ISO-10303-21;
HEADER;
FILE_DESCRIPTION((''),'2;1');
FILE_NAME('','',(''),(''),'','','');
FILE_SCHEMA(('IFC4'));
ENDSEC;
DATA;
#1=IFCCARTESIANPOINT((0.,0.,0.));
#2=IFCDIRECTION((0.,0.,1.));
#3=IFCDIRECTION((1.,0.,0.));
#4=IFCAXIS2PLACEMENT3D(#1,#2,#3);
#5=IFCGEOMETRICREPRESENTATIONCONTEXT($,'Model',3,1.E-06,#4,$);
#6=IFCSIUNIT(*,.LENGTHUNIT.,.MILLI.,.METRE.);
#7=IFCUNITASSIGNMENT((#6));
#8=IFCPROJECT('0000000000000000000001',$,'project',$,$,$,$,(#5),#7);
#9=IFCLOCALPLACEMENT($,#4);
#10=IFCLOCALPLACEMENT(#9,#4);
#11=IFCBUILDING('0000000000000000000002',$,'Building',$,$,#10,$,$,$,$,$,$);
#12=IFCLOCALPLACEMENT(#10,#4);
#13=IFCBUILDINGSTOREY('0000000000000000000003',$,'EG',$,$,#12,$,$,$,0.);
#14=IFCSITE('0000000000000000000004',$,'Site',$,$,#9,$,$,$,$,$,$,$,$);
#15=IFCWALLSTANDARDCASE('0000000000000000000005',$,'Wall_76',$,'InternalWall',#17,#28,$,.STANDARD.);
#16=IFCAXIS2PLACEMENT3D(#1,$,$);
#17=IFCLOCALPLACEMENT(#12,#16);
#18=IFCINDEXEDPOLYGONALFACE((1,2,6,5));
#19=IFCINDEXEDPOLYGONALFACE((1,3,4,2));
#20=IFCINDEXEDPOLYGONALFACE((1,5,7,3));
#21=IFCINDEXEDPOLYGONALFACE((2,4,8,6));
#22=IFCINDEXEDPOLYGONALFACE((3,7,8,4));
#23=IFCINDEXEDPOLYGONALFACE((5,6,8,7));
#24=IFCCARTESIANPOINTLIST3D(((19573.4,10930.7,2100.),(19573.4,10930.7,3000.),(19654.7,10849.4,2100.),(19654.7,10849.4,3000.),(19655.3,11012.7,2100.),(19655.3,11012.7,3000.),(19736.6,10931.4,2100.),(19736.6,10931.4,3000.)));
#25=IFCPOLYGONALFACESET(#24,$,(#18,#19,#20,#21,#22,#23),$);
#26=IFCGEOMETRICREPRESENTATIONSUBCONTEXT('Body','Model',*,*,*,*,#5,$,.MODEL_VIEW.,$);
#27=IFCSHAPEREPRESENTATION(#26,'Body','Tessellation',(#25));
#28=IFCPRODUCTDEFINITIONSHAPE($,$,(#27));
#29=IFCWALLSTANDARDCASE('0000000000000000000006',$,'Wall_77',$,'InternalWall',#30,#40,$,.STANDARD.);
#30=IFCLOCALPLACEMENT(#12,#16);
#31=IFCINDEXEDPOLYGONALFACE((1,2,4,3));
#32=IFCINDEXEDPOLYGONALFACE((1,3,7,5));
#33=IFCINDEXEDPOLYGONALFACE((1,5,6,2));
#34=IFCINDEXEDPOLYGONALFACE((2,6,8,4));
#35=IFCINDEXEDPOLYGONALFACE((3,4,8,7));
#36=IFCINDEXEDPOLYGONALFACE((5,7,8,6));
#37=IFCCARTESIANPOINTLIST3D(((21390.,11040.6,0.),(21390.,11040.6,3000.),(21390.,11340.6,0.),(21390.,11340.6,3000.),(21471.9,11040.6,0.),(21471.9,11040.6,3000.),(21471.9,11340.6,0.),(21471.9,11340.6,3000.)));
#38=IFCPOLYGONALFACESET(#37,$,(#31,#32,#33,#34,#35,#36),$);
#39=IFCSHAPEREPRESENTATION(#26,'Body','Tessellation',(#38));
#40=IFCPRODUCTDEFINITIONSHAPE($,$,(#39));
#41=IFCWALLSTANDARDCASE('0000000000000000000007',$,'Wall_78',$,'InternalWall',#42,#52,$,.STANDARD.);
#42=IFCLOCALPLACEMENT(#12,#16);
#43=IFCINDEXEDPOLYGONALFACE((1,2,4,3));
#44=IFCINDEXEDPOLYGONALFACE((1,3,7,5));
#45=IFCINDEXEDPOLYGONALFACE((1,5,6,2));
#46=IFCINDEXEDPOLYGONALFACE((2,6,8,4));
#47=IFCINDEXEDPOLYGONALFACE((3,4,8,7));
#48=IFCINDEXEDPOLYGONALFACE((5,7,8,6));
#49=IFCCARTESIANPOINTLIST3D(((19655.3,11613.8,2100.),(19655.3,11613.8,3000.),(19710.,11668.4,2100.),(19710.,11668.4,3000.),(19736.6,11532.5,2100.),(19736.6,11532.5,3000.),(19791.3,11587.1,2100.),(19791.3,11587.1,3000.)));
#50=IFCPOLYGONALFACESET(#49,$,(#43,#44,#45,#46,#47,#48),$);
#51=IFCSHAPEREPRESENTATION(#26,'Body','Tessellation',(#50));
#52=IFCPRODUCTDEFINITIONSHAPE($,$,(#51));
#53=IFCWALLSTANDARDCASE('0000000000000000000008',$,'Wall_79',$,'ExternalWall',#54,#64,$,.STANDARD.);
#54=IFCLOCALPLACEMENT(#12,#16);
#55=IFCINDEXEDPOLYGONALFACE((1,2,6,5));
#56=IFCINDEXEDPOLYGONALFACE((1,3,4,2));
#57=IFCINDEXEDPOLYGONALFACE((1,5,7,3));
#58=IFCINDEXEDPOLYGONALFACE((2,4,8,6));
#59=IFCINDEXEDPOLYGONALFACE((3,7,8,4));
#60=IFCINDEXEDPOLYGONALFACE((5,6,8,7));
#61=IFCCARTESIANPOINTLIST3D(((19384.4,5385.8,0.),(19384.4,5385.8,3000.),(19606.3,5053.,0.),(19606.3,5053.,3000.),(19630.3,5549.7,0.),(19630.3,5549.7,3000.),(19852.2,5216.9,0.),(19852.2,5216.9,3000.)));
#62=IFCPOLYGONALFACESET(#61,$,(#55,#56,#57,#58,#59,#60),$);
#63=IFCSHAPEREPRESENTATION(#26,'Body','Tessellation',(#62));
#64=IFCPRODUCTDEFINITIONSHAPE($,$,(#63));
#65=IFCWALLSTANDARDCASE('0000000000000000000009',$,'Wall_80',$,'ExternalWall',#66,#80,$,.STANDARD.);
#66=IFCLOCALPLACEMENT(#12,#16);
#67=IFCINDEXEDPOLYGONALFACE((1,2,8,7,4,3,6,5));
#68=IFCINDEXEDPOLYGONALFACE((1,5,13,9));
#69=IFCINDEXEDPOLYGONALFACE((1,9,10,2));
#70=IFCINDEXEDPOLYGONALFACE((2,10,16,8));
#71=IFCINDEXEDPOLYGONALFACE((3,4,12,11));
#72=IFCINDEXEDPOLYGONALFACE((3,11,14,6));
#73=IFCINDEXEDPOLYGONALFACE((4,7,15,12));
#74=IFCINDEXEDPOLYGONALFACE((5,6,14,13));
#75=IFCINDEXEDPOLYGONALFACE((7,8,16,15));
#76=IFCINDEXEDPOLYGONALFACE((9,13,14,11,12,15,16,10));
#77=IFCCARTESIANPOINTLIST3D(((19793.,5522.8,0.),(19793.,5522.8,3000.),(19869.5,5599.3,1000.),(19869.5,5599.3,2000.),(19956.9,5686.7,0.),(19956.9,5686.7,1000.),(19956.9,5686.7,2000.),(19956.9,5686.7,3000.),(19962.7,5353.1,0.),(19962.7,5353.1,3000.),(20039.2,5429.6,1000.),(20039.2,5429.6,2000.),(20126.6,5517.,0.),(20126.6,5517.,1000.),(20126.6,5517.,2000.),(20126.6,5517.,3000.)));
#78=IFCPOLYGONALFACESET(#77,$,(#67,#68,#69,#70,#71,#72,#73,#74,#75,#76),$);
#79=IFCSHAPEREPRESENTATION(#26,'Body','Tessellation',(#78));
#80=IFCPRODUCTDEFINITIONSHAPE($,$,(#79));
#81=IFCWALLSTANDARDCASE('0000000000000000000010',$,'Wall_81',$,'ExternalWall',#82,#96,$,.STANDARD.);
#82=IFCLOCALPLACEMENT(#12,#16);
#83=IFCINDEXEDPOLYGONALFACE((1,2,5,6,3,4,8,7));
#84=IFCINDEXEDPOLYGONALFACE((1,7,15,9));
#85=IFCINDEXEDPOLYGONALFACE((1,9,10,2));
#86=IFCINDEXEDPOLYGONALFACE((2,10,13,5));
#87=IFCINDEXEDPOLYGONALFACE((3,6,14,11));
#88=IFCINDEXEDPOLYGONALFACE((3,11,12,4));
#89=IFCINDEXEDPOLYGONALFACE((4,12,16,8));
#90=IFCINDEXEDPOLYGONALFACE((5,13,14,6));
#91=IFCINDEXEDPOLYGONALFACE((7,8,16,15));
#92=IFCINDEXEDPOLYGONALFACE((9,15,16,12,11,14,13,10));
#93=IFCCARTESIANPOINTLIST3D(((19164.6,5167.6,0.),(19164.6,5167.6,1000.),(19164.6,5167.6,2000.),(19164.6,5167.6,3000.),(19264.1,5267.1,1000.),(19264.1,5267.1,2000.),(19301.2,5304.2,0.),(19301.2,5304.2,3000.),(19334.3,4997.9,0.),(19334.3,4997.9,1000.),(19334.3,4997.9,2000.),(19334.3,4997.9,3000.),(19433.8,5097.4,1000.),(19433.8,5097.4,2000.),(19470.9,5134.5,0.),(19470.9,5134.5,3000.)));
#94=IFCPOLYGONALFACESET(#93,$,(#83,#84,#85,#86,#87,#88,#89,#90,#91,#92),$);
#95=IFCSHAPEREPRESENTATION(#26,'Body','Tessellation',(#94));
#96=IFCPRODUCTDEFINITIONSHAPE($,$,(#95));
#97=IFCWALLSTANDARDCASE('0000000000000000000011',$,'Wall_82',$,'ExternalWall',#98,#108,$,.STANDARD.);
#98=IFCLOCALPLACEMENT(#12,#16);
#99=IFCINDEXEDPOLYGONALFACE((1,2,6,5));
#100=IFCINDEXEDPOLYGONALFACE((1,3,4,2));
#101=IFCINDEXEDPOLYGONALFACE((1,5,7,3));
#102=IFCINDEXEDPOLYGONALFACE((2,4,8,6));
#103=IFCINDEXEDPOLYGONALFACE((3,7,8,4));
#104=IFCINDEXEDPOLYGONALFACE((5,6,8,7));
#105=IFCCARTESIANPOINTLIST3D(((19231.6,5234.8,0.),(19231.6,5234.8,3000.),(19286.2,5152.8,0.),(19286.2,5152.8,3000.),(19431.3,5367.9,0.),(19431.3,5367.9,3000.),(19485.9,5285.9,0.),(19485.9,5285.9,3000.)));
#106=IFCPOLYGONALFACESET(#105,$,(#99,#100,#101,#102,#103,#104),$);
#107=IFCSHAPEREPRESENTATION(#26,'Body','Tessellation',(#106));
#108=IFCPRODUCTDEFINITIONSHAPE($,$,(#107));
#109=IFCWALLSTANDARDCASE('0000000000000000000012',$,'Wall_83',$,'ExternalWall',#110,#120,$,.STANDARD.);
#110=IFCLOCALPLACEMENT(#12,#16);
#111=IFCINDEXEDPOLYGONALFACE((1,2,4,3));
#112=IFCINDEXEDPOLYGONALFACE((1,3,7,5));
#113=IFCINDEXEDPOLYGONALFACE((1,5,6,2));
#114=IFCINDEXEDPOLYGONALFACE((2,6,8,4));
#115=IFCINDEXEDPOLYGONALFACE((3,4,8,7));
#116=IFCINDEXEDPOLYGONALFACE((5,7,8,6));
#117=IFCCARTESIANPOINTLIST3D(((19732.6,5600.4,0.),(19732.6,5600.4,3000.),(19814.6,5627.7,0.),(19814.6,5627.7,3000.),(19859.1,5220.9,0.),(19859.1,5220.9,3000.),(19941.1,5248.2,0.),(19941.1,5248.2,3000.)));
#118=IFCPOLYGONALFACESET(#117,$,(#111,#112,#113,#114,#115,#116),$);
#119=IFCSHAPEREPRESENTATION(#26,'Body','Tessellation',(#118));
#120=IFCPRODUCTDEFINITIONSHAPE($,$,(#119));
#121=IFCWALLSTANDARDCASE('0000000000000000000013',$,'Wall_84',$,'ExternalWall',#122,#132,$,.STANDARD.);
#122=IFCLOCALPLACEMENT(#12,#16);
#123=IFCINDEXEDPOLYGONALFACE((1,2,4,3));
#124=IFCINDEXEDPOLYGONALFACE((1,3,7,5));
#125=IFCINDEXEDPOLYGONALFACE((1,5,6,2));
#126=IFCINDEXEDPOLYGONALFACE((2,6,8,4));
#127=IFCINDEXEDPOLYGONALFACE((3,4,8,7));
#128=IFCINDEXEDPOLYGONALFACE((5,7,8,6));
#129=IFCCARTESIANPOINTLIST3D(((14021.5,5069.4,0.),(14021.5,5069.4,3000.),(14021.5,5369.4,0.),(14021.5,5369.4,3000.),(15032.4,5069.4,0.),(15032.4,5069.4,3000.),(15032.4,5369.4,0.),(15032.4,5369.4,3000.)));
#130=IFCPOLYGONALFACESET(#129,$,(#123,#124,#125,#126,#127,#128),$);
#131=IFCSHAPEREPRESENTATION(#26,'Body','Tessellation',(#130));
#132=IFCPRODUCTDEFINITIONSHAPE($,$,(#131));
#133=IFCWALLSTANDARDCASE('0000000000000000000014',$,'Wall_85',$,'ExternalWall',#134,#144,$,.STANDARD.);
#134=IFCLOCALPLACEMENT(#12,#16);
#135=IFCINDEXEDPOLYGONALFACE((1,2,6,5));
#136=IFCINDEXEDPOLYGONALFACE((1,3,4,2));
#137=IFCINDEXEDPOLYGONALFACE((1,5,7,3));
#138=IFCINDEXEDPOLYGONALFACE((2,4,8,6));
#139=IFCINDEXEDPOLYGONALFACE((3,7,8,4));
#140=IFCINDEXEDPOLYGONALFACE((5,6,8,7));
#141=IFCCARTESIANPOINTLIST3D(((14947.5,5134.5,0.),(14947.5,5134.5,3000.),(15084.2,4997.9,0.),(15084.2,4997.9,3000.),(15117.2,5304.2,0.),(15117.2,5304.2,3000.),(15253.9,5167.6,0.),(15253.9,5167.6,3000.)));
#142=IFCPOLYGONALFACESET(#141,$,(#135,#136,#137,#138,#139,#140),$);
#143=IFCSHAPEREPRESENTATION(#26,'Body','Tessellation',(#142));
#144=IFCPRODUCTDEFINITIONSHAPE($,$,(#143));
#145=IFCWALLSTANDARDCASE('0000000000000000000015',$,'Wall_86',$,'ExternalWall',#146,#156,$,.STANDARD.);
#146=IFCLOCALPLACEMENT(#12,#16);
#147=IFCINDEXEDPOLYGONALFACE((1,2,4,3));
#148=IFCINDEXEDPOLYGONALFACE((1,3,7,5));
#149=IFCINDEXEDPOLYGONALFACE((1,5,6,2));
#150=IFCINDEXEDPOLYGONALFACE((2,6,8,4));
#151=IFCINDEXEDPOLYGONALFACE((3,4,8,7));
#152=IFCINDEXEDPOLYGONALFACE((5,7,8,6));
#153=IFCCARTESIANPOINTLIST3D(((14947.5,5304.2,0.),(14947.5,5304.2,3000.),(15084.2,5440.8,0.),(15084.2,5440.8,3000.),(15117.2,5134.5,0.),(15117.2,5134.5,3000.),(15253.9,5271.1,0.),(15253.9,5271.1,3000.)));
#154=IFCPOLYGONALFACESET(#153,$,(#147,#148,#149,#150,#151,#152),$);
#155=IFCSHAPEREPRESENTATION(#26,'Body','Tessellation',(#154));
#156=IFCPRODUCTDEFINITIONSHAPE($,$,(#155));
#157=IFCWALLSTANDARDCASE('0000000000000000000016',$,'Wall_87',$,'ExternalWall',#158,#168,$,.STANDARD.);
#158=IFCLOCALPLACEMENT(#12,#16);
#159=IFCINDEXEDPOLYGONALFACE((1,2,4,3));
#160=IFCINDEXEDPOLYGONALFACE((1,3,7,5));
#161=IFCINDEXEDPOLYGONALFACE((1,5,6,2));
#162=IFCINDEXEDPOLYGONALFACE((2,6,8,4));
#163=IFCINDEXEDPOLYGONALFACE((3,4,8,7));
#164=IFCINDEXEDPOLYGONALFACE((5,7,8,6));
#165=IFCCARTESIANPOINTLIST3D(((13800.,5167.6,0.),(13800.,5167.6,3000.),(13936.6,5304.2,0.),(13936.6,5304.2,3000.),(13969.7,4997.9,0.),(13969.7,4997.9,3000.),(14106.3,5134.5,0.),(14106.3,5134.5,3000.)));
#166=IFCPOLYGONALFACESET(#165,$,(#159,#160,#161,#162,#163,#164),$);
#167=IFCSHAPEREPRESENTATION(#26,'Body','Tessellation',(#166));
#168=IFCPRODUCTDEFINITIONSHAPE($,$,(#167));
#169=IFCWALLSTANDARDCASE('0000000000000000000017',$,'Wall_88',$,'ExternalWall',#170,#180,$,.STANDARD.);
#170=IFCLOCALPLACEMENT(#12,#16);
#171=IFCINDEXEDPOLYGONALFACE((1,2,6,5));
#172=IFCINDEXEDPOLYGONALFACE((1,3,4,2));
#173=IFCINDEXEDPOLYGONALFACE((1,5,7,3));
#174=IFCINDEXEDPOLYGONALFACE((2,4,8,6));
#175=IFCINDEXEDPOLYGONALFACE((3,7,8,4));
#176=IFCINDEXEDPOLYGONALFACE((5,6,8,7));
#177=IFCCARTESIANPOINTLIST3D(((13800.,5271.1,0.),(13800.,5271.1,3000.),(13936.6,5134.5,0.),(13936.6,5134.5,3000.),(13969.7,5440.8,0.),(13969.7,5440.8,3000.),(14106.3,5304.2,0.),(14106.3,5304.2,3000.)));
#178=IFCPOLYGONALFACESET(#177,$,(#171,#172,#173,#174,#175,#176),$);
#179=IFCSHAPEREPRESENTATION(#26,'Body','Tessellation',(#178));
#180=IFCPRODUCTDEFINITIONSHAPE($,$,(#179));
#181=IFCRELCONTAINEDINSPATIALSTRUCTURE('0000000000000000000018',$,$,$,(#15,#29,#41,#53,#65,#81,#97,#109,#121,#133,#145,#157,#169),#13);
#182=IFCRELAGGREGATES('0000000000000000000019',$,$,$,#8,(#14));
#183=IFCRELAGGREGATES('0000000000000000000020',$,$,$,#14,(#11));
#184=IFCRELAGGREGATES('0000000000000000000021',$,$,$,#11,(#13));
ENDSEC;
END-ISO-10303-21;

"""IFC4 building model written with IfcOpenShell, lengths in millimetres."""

from ifc_helpers import new_model, si_unit, frame, origin_with_axes, place, context, subcontext, project, spatial, rectangle, extrude, element, save


model = new_model("IFC4")

# Units and contexts
model_context = context("Model", 3, precision=1e-06, world=origin_with_axes())
body_context = subcontext(model_context, "Body", "Model", "MODEL_VIEW")
ifc_project = project(units=[si_unit("LENGTHUNIT", "METRE", prefix="MILLI")], contexts=[model_context])

# Site, building, storey
site_placement = place(None, origin_with_axes())
site = spatial("IfcSite", under=ifc_project, at=site_placement, Name="Site")
building_placement = place(site_placement, origin_with_axes())
building = spatial("IfcBuilding", under=site, at=building_placement, Name="Building")
storey_placement = place(building_placement, origin_with_axes())
storey = spatial("IfcBuildingStorey", under=building, at=storey_placement, Name="EG", Elevation=0.0)

# Wall, opening
wall_1_placement = place(storey_placement, origin_with_axes())
wall_1 = element("IfcWallStandardCase", 1, at=wall_1_placement, inside=storey, Name="Wall_76", ObjectType="InternalWall", PredefinedType="STANDARD", context=body_context, shape_type="SweptSolid", body=[
    extrude(rectangle(XDim=115.9, YDim=115.0), frame((19655.0, 10931.0, 0.0), z_axis=(0.0, 0.0, 1.0), x_axis=(-0.707107, -0.707107, 0.0)), (0.0, 0.0, 1.0), 3000.0),
])
opening_1_placement = place(wall_1_placement, origin_with_axes())
element("IfcOpeningElement", 2, at=opening_1_placement, inside=storey, cuts=wall_1, context=body_context, shape_type="SweptSolid", body=[
    extrude(rectangle(XDim=1510.0, YDim=115.0), frame((19635.4, 10911.5, 0.0), z_axis=(0.0, 0.0, 1.0), x_axis=(-0.707107, -0.707107, 0.0)), (0.0, 0.0, 1.0), 2100.0),
])

# Wall
wall_2_placement = place(storey_placement, origin_with_axes())
element("IfcWallStandardCase", 3, at=wall_2_placement, inside=storey, Name="Wall_77", ObjectType="InternalWall", PredefinedType="STANDARD", context=body_context, shape_type="SweptSolid", body=[
    extrude(rectangle(XDim=82.0, YDim=300.0), frame((21431.0, 11190.6, 0.0), z_axis=(0.0, 0.0, 1.0), x_axis=(-1.0, 0.0, 0.0)), (0.0, 0.0, 1.0), 3000.0),
])

# Wall, opening
wall_3_placement = place(storey_placement, origin_with_axes())
wall_3 = element("IfcWallStandardCase", 4, at=wall_3_placement, inside=storey, Name="Wall_78", ObjectType="InternalWall", PredefinedType="STANDARD", context=body_context, shape_type="SweptSolid", body=[
    extrude(rectangle(XDim=77.3, YDim=115.0), frame((19723.3, 11600.4, 0.0), z_axis=(0.0, 0.0, 1.0), x_axis=(0.707107, 0.707107, 0.0)), (0.0, 0.0, 1.0), 3000.0),
])
opening_2_placement = place(wall_3_placement, origin_with_axes())
element("IfcOpeningElement", 5, at=opening_2_placement, inside=storey, cuts=wall_3, context=body_context, shape_type="SweptSolid", body=[
    extrude(rectangle(XDim=902.3, YDim=115.0), frame((20005.4, 11882.6, 0.0), z_axis=(0.0, 0.0, 1.0), x_axis=(0.707107, 0.707107, 0.0)), (0.0, 0.0, 1.0), 2100.0),
])

# Wall
wall_4_placement = place(storey_placement, origin_with_axes())
element("IfcWallStandardCase", 6, at=wall_4_placement, inside=storey, Name="Wall_79", ObjectType="ExternalWall", PredefinedType="STANDARD", context=body_context, shape_type="SweptSolid", body=[
    extrude(rectangle(XDim=295.5, YDim=400.0), frame((19618.3, 5301.3, 0.0), z_axis=(0.0, 0.0, 1.0), x_axis=(-0.83205, -0.5547, 0.0)), (0.0, 0.0, 1.0), 3000.0),
])

# Walls, openings
wall_5_placement = place(storey_placement, origin_with_axes())
wall_5 = element("IfcWallStandardCase", 7, at=wall_5_placement, inside=storey, Name="Wall_80", ObjectType="ExternalWall", PredefinedType="STANDARD", context=body_context, shape_type="SweptSolid", body=[
    extrude(rectangle(XDim=231.8, YDim=240.0), frame((19959.8, 5519.9, 0.0), z_axis=(0.0, 0.0, 1.0), x_axis=(-0.707107, -0.707107, 0.0)), (0.0, 0.0, 1.0), 3000.0),
])
opening_3_placement = place(wall_5_placement, origin_with_axes())
element("IfcOpeningElement", 8, at=opening_3_placement, inside=storey, cuts=wall_5, context=body_context, shape_type="SweptSolid", body=[
    extrude(rectangle(XDim=2633.2, YDim=240.0), frame((20885.3, 6445.4, 1000.0), z_axis=(0.0, 0.0, 1.0), x_axis=(-0.707107, -0.707107, 0.0)), (0.0, 0.0, 1.0), 1000.0),
])
wall_6_placement = place(storey_placement, origin_with_axes())
wall_6 = element("IfcWallStandardCase", 9, at=wall_6_placement, inside=storey, Name="Wall_81", ObjectType="ExternalWall", PredefinedType="STANDARD", context=body_context, shape_type="SweptSolid", body=[
    extrude(rectangle(XDim=193.2, YDim=240.0), frame((19317.7, 5151.1, 0.0), z_axis=(0.0, 0.0, 1.0), x_axis=(-0.707107, -0.707107, 0.0)), (0.0, 0.0, 1.0), 3000.0),
])
opening_4_placement = place(wall_6_placement, origin_with_axes())
element("IfcOpeningElement", 10, at=opening_4_placement, inside=storey, cuts=wall_6, context=body_context, shape_type="SweptSolid", body=[
    extrude(rectangle(XDim=1068.0, YDim=240.0), frame((18971.4, 4804.7, 1000.0), z_axis=(0.0, 0.0, 1.0), x_axis=(-0.707107, -0.707107, 0.0)), (0.0, 0.0, 1.0), 1000.0),
])

# Walls
wall_7_placement = place(storey_placement, origin_with_axes())
element("IfcWallStandardCase", 11, at=wall_7_placement, inside=storey, Name="Wall_82", ObjectType="ExternalWall", PredefinedType="STANDARD", context=body_context, shape_type="SweptSolid", body=[
    extrude(rectangle(XDim=98.5, YDim=240.0), frame((19358.7, 5260.4, 0.0), z_axis=(0.0, 0.0, 1.0), x_axis=(-0.5547, 0.83205, 0.0)), (0.0, 0.0, 1.0), 3000.0),
])
wall_8_placement = place(storey_placement, origin_with_axes())
element("IfcWallStandardCase", 12, at=wall_8_placement, inside=storey, Name="Wall_83", ObjectType="ExternalWall", PredefinedType="STANDARD", context=body_context, shape_type="SweptSolid", body=[
    extrude(rectangle(XDim=86.4, YDim=400.0), frame((19836.9, 5424.3, 0.0), z_axis=(0.0, 0.0, 1.0), x_axis=(-0.948683, -0.316228, 0.0)), (0.0, 0.0, 1.0), 3000.0),
])
wall_9_placement = place(storey_placement, origin_with_axes())
element("IfcWallStandardCase", 13, at=wall_9_placement, inside=storey, Name="Wall_84", ObjectType="ExternalWall", PredefinedType="STANDARD", context=body_context, shape_type="SweptSolid", body=[
    extrude(rectangle(XDim=1010.9, YDim=300.0), frame((14526.9, 5219.4, 0.0), z_axis=(0.0, 0.0, 1.0), x_axis=(-1.0, 0.0, 0.0)), (0.0, 0.0, 1.0), 3000.0),
])
wall_10_placement = place(storey_placement, origin_with_axes())
element("IfcWallStandardCase", 14, at=wall_10_placement, inside=storey, Name="Wall_85", ObjectType="ExternalWall", PredefinedType="STANDARD", context=body_context, shape_type="SweptSolid", body=[
    extrude(rectangle(XDim=193.2, YDim=240.0), frame((15100.7, 5151.1, 0.0), z_axis=(0.0, 0.0, 1.0), x_axis=(0.707107, -0.707107, 0.0)), (0.0, 0.0, 1.0), 3000.0),
])
wall_11_placement = place(storey_placement, origin_with_axes())
element("IfcWallStandardCase", 15, at=wall_11_placement, inside=storey, Name="Wall_86", ObjectType="ExternalWall", PredefinedType="STANDARD", context=body_context, shape_type="SweptSolid", body=[
    extrude(rectangle(XDim=193.2, YDim=240.0), frame((15100.7, 5287.7, 0.0), z_axis=(0.0, 0.0, 1.0), x_axis=(0.707107, 0.707107, 0.0)), (0.0, 0.0, 1.0), 3000.0),
])
wall_12_placement = place(storey_placement, origin_with_axes())
element("IfcWallStandardCase", 16, at=wall_12_placement, inside=storey, Name="Wall_87", ObjectType="ExternalWall", PredefinedType="STANDARD", context=body_context, shape_type="SweptSolid", body=[
    extrude(rectangle(XDim=193.2, YDim=240.0), frame((13953.2, 5151.1, 0.0), z_axis=(0.0, 0.0, 1.0), x_axis=(-0.707107, -0.707107, 0.0)), (0.0, 0.0, 1.0), 3000.0),
])
wall_13_placement = place(storey_placement, origin_with_axes())
element("IfcWallStandardCase", 17, at=wall_13_placement, inside=storey, Name="Wall_88", ObjectType="ExternalWall", PredefinedType="STANDARD", context=body_context, shape_type="SweptSolid", body=[
    extrude(rectangle(XDim=193.2, YDim=240.0), frame((13953.2, 5287.7, 0.0), z_axis=(0.0, 0.0, 1.0), x_axis=(-0.707107, 0.707107, 0.0)), (0.0, 0.0, 1.0), 3000.0),
])

save(model, "model.ifc")
